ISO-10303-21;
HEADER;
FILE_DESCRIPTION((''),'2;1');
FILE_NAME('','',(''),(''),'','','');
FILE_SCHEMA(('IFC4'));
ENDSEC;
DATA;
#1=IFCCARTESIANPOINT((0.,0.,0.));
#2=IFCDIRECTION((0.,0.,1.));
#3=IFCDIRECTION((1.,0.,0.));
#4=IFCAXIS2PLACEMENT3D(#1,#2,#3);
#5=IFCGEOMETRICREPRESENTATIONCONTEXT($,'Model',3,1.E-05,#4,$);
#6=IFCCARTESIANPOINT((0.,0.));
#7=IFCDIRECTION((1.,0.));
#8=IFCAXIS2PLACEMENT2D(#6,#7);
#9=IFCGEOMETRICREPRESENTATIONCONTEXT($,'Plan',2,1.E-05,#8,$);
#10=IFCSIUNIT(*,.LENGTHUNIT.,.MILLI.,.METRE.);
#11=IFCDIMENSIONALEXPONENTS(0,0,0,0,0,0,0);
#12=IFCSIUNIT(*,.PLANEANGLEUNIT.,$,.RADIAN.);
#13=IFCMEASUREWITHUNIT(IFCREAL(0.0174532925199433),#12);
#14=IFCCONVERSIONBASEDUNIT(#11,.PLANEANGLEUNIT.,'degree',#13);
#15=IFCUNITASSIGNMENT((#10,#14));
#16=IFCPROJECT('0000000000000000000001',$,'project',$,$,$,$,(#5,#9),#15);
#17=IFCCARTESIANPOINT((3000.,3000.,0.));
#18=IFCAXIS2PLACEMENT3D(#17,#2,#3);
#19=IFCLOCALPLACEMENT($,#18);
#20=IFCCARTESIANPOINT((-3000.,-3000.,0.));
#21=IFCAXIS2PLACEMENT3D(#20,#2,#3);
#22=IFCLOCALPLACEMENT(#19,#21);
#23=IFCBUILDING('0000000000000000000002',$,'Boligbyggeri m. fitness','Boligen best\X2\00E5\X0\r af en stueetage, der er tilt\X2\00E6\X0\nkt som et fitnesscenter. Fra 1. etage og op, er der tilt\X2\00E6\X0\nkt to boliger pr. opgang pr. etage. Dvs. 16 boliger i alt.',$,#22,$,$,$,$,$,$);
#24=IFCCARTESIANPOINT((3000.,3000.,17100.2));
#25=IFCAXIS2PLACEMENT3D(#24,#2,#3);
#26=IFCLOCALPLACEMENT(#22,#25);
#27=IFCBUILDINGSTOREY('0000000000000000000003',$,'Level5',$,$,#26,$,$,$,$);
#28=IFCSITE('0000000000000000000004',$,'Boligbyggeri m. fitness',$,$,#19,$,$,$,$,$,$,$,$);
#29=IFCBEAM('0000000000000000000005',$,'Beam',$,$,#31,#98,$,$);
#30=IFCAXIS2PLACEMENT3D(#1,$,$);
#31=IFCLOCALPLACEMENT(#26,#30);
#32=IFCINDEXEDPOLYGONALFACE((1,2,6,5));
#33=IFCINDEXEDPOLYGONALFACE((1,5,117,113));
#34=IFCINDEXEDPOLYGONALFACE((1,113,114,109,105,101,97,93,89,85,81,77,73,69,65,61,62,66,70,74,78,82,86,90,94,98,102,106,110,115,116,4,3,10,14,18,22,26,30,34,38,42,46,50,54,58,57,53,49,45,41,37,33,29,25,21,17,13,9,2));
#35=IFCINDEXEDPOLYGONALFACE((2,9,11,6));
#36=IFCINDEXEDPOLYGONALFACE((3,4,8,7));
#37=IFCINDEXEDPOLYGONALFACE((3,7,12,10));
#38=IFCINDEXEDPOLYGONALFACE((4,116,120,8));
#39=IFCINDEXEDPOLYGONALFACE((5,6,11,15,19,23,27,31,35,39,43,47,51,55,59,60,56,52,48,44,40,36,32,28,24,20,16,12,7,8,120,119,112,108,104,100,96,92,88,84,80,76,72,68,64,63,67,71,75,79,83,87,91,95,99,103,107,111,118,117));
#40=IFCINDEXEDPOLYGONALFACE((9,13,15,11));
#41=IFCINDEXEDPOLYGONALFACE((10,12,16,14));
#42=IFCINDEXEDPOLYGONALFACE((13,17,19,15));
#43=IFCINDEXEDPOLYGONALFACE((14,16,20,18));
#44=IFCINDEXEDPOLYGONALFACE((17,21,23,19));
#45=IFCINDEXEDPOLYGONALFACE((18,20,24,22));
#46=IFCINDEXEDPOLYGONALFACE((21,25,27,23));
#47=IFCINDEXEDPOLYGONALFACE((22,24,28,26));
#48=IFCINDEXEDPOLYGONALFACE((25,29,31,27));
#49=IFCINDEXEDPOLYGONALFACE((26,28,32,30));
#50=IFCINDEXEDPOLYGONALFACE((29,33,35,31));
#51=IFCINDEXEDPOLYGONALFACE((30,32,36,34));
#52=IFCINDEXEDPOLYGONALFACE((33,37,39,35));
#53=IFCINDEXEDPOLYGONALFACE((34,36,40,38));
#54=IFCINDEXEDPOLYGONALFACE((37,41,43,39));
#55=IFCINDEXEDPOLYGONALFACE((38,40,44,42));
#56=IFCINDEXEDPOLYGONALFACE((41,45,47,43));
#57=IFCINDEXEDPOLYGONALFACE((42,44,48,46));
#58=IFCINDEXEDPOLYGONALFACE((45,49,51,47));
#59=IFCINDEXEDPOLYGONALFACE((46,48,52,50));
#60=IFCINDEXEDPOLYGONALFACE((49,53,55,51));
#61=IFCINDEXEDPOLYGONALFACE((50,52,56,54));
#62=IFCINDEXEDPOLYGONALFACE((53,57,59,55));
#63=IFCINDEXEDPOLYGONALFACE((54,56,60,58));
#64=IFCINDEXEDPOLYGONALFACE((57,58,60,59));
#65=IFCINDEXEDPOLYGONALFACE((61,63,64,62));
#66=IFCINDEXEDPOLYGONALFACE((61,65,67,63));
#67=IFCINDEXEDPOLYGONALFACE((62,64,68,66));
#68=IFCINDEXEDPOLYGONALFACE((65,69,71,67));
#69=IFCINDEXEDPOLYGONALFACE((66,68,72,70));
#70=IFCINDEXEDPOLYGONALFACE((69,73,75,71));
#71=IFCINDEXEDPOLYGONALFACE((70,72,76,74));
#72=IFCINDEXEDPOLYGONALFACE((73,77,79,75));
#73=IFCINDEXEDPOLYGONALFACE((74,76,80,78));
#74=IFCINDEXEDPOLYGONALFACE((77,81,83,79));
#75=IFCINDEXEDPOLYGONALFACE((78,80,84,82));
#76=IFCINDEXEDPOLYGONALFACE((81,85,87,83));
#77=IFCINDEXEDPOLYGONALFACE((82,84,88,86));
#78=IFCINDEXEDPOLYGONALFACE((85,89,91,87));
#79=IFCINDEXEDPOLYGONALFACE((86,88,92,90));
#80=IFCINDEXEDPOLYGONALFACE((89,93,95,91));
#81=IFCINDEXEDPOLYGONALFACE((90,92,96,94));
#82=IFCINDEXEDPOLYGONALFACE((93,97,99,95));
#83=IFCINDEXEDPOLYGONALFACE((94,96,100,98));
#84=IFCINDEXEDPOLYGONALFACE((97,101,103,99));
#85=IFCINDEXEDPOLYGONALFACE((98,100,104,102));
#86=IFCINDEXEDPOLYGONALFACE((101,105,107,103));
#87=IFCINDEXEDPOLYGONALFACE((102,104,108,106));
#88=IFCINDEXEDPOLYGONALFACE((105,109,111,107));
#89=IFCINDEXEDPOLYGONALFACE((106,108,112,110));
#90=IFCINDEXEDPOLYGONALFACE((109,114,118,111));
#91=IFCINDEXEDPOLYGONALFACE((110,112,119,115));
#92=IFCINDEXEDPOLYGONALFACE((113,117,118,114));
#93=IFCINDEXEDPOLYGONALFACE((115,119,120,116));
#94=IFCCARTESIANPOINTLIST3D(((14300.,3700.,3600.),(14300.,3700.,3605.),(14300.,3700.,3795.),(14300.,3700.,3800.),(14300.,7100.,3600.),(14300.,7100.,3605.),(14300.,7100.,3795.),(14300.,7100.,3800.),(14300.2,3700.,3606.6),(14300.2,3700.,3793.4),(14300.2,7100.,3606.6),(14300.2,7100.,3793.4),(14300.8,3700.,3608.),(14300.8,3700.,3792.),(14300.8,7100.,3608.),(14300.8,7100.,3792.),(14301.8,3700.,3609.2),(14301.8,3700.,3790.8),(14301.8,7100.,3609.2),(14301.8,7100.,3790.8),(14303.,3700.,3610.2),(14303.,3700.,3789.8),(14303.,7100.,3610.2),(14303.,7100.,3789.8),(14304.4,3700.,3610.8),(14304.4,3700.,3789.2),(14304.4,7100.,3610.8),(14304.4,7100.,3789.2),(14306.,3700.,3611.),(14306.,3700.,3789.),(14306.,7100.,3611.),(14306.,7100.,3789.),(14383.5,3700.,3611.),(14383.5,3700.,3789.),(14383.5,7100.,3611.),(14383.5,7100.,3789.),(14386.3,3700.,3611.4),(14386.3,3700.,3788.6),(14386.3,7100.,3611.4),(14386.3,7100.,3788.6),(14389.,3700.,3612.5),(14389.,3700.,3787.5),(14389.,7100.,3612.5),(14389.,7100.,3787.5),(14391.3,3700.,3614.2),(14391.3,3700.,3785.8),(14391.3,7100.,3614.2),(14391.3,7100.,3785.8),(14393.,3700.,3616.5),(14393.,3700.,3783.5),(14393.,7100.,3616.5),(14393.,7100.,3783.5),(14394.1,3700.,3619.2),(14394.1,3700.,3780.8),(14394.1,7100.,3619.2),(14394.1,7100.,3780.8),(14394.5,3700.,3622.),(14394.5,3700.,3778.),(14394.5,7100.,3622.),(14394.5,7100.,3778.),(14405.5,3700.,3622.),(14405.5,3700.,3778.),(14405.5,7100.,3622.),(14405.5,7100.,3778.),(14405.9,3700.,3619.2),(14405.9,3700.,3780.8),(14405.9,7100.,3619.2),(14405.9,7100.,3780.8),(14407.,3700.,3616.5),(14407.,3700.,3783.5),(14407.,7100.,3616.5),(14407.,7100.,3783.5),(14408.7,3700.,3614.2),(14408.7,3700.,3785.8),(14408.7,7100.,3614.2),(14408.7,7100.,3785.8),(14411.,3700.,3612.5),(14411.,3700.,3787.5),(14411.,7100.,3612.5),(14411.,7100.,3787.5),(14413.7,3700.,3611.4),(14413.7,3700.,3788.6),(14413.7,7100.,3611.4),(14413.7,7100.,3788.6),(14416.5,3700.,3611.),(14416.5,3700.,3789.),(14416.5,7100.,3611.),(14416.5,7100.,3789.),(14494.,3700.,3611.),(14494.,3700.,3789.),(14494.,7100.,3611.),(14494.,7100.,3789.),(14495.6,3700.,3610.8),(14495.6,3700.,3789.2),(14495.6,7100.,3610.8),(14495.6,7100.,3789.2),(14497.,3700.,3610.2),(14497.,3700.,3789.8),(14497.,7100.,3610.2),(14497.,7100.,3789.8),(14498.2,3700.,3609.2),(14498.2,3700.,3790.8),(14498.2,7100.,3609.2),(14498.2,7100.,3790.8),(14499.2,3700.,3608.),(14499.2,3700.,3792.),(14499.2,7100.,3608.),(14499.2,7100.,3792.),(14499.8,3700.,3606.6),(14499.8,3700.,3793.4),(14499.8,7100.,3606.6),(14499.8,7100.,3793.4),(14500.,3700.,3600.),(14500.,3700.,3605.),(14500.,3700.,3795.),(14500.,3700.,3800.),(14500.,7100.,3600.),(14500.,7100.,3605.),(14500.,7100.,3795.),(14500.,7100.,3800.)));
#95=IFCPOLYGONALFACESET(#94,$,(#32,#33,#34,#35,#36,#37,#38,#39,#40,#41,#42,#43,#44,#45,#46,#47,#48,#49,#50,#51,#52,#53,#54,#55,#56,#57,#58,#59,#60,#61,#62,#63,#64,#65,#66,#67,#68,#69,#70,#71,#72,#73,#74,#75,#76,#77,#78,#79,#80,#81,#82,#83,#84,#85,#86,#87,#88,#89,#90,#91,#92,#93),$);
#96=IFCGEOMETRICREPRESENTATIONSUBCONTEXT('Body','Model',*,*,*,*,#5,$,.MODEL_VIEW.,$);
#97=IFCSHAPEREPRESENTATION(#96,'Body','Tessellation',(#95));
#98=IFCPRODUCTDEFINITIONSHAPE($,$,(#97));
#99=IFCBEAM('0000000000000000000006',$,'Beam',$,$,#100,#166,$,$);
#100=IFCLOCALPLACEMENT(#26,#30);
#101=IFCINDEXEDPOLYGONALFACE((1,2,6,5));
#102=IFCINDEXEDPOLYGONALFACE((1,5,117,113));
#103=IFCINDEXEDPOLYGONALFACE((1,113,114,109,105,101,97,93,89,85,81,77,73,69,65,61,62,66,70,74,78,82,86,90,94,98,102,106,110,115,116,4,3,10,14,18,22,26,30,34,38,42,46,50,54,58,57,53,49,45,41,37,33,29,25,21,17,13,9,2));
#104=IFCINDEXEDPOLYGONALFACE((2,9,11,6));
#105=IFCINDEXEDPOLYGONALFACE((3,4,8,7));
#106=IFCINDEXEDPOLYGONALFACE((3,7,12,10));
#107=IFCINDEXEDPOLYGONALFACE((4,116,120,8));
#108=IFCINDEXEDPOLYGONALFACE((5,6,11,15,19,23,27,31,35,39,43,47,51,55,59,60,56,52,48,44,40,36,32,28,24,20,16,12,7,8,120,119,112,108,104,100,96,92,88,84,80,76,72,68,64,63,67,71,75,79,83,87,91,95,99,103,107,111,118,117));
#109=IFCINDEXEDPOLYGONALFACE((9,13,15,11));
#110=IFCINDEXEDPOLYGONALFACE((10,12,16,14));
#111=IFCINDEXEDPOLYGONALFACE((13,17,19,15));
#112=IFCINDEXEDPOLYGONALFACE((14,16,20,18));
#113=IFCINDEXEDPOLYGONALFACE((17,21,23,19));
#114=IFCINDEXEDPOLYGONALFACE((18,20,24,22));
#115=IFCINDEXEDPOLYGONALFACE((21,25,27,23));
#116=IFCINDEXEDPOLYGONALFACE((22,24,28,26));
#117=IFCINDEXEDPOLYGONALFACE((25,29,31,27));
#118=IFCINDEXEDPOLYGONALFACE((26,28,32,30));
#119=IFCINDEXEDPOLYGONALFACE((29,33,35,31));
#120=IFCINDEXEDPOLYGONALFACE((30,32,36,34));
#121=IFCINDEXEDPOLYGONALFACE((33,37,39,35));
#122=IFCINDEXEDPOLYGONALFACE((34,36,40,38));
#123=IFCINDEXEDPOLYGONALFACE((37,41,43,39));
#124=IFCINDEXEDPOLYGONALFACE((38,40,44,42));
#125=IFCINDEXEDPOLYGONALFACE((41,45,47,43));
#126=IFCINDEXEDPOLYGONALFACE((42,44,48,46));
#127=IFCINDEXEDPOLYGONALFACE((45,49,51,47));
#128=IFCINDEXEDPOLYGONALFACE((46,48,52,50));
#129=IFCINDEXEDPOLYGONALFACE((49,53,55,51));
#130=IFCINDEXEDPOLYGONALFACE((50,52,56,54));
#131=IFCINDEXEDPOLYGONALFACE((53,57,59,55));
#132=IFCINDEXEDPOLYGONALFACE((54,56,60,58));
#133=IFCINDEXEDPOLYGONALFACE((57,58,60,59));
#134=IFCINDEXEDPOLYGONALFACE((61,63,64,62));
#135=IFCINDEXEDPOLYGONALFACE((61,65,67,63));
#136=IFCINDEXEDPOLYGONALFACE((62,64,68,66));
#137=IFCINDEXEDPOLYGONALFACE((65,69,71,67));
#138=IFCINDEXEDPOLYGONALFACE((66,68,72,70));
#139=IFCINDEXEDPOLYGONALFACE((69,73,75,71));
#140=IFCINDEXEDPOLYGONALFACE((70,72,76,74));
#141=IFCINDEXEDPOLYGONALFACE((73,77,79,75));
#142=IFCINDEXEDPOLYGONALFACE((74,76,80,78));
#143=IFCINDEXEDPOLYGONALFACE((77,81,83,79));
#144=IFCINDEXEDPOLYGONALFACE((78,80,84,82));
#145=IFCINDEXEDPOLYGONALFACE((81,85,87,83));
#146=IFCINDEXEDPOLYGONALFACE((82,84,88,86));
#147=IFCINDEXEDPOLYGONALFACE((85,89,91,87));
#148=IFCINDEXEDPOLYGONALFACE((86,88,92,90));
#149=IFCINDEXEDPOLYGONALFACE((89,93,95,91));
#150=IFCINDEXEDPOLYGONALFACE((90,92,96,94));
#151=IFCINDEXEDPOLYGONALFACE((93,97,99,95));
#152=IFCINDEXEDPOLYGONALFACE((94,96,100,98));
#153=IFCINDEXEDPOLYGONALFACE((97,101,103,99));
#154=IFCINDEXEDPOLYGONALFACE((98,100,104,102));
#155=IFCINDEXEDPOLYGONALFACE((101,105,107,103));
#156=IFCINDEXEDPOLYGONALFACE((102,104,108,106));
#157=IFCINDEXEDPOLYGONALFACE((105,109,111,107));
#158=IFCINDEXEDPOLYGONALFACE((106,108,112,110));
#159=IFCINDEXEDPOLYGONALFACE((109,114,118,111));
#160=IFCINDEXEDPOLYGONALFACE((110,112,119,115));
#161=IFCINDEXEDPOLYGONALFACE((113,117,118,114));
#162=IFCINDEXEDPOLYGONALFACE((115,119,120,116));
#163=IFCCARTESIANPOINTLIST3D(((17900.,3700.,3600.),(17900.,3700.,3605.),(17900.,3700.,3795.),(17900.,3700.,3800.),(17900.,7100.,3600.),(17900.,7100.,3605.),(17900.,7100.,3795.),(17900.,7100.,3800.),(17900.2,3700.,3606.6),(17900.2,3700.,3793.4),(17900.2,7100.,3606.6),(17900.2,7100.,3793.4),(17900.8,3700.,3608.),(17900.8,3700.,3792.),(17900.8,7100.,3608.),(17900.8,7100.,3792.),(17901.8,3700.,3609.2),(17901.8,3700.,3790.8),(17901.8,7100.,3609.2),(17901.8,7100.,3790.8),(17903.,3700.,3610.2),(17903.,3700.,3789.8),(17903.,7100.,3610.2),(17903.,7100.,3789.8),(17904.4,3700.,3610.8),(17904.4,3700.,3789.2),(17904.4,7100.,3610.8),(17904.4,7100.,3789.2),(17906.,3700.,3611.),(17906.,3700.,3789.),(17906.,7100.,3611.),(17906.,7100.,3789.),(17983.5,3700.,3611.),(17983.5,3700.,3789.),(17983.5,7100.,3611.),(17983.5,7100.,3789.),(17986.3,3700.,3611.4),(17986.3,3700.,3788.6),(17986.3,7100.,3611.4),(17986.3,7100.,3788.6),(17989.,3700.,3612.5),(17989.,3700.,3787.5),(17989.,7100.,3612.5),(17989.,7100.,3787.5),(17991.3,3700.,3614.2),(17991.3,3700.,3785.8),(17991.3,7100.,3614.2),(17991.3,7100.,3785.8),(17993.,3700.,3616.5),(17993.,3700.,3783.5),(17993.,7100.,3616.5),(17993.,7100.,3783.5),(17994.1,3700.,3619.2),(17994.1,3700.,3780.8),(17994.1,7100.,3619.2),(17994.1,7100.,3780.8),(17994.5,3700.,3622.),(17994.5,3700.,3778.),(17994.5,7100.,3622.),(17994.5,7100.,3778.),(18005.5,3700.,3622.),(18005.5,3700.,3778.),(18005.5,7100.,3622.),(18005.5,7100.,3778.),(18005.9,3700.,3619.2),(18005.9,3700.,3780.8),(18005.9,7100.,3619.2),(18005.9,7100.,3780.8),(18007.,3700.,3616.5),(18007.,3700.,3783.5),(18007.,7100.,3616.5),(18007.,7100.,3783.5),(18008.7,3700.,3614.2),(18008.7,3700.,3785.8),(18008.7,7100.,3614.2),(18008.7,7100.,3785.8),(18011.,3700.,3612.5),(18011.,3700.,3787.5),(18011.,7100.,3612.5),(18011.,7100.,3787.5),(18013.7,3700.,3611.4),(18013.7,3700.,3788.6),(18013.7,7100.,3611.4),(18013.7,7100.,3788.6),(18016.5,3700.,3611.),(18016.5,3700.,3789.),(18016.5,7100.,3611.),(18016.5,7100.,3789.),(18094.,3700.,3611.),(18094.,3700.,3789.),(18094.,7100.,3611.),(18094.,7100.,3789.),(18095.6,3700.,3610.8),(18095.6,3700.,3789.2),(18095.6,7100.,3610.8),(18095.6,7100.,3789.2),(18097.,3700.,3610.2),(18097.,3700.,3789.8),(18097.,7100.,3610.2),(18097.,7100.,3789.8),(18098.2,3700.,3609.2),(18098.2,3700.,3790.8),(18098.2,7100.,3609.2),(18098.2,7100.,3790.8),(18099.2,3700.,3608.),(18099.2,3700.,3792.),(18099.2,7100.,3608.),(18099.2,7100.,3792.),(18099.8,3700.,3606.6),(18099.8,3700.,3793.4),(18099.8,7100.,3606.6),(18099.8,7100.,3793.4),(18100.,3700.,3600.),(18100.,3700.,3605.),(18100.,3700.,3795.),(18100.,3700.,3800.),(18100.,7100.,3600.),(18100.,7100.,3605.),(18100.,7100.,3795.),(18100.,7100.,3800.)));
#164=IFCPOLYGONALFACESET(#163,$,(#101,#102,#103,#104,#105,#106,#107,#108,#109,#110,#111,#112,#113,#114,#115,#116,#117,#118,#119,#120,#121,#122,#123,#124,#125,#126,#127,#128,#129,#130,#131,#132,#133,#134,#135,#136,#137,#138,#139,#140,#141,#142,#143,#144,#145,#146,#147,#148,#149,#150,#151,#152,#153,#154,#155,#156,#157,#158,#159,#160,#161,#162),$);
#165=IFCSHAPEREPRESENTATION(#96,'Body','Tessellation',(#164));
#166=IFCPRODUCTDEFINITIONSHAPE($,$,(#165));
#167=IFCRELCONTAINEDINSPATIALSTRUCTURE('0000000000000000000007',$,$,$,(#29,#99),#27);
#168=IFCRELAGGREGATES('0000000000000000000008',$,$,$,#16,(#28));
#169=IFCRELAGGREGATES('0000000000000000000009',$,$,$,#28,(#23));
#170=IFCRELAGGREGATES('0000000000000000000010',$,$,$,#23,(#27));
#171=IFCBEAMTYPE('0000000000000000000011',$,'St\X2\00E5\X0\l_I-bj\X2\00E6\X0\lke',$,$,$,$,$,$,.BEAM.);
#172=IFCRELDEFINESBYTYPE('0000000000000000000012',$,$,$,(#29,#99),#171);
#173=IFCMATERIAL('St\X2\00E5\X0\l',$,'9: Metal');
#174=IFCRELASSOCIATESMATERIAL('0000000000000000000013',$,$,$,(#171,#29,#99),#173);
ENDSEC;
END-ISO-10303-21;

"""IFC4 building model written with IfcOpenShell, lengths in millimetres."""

from ifc_helpers import new_model, entity, si_unit, converted_unit, frame, origin_with_axes, origin_2d_with_axis, place, context, subcontext, project, spatial, i_section, extrude, material, material_profile, profile_set, profile_usage, type_object, element, save


model = new_model("IFC4")

# Units and contexts
model_context = context("Model", 3, precision=1e-05, world=origin_with_axes())
plan_context = context("Plan", 2, precision=1e-05, world=origin_2d_with_axis())
body_context = subcontext(model_context, "Body", "Model", "MODEL_VIEW")
ifc_project = project(units=[si_unit("LENGTHUNIT", "METRE", prefix="MILLI"), converted_unit("PLANEANGLEUNIT", "degree", entity("IfcReal", 0.0174532925199433), si_unit("PLANEANGLEUNIT", "RADIAN"), dimensions=[0, 0, 0, 0, 0, 0, 0])], contexts=[model_context, plan_context])

# Site, building, storey
site_placement = place(None, frame((3000.0, 3000.0, 0.0), z_axis=(0.0, 0.0, 1.0), x_axis=(1.0, 0.0, 0.0)))
site = spatial("IfcSite", under=ifc_project, at=site_placement, Name="Boligbyggeri m. fitness")
building_placement = place(site_placement, frame((-3000.0, -3000.0, 0.0), z_axis=(0.0, 0.0, 1.0), x_axis=(1.0, 0.0, 0.0)))
building = spatial("IfcBuilding", under=site, at=building_placement, Name="Boligbyggeri m. fitness", Description="Boligen består af en stueetage, der er tiltænkt som et fitnesscenter. Fra 1. etage og op, er der tiltænkt to boliger pr. opgang pr. etage. Dvs. 16 boliger i alt.")
storey_placement = place(building_placement, frame((3000.0, 3000.0, 17100.2), z_axis=(0.0, 0.0, 1.0), x_axis=(1.0, 0.0, 0.0)))
storey = spatial("IfcBuildingStorey", under=building, at=storey_placement, Name="Level5")

# Beams
ifc_material_1 = material(Name="Stål", Category="9: Metal")
ifc_material_profile_1 = material_profile(ifc_material_1, i_section(OverallWidth=200.0, OverallDepth=200.0, WebThickness=11.0, FlangeThickness=11.0, FilletRadius=11.0, FlangeEdgeRadius=6.0), Name="Stål", Category="9: Metal")
ifc_profile_set_1 = profile_set([ifc_material_profile_1], Name="NY_I-Profil")
beam_type = type_object("IfcBeamType", Name="Stål_I-bjælke", PredefinedType="BEAM", material=ifc_profile_set_1)
ifc_profile_usage_1 = profile_usage(ifc_profile_set_1, cardinal=9)
beam_1_placement = place(storey_placement, frame((14500.0, 3700.0, 3800.0), z_axis=(0.0, 1.0, 0.0), x_axis=(-1.0, 0.0, 0.0)))
element("IfcBeam", 1, at=beam_1_placement, inside=storey, type_object=beam_type, material=ifc_profile_usage_1, Name="Beam", context=body_context, shape_type="SweptSolid", body=[
    extrude(i_section(OverallWidth=200.0, OverallDepth=200.0, WebThickness=11.0, FlangeThickness=11.0, FilletRadius=11.0, FlangeEdgeRadius=6.0), frame((100.0, -100.0, 0.0), z_axis=(0.0, 0.0, 1.0), x_axis=(1.0, 0.0, 0.0)), (0.0, 0.0, 1.0), 3400.0),
])
ifc_profile_usage_2 = profile_usage(ifc_profile_set_1, cardinal=9)
beam_2_placement = place(storey_placement, frame((18100.0, 3700.0, 3800.0), z_axis=(0.0, 1.0, 0.0), x_axis=(-1.0, 0.0, 0.0)))
element("IfcBeam", 2, at=beam_2_placement, inside=storey, type_object=beam_type, material=ifc_profile_usage_2, Name="Beam", context=body_context, shape_type="SweptSolid", body=[
    extrude(i_section(OverallWidth=200.0, OverallDepth=200.0, WebThickness=11.0, FlangeThickness=11.0, FilletRadius=11.0, FlangeEdgeRadius=6.0), frame((100.0, -100.0, 0.0), z_axis=(0.0, 0.0, 1.0), x_axis=(1.0, 0.0, 0.0)), (0.0, 0.0, 1.0), 3400.0),
])

save(model, "model.ifc")
